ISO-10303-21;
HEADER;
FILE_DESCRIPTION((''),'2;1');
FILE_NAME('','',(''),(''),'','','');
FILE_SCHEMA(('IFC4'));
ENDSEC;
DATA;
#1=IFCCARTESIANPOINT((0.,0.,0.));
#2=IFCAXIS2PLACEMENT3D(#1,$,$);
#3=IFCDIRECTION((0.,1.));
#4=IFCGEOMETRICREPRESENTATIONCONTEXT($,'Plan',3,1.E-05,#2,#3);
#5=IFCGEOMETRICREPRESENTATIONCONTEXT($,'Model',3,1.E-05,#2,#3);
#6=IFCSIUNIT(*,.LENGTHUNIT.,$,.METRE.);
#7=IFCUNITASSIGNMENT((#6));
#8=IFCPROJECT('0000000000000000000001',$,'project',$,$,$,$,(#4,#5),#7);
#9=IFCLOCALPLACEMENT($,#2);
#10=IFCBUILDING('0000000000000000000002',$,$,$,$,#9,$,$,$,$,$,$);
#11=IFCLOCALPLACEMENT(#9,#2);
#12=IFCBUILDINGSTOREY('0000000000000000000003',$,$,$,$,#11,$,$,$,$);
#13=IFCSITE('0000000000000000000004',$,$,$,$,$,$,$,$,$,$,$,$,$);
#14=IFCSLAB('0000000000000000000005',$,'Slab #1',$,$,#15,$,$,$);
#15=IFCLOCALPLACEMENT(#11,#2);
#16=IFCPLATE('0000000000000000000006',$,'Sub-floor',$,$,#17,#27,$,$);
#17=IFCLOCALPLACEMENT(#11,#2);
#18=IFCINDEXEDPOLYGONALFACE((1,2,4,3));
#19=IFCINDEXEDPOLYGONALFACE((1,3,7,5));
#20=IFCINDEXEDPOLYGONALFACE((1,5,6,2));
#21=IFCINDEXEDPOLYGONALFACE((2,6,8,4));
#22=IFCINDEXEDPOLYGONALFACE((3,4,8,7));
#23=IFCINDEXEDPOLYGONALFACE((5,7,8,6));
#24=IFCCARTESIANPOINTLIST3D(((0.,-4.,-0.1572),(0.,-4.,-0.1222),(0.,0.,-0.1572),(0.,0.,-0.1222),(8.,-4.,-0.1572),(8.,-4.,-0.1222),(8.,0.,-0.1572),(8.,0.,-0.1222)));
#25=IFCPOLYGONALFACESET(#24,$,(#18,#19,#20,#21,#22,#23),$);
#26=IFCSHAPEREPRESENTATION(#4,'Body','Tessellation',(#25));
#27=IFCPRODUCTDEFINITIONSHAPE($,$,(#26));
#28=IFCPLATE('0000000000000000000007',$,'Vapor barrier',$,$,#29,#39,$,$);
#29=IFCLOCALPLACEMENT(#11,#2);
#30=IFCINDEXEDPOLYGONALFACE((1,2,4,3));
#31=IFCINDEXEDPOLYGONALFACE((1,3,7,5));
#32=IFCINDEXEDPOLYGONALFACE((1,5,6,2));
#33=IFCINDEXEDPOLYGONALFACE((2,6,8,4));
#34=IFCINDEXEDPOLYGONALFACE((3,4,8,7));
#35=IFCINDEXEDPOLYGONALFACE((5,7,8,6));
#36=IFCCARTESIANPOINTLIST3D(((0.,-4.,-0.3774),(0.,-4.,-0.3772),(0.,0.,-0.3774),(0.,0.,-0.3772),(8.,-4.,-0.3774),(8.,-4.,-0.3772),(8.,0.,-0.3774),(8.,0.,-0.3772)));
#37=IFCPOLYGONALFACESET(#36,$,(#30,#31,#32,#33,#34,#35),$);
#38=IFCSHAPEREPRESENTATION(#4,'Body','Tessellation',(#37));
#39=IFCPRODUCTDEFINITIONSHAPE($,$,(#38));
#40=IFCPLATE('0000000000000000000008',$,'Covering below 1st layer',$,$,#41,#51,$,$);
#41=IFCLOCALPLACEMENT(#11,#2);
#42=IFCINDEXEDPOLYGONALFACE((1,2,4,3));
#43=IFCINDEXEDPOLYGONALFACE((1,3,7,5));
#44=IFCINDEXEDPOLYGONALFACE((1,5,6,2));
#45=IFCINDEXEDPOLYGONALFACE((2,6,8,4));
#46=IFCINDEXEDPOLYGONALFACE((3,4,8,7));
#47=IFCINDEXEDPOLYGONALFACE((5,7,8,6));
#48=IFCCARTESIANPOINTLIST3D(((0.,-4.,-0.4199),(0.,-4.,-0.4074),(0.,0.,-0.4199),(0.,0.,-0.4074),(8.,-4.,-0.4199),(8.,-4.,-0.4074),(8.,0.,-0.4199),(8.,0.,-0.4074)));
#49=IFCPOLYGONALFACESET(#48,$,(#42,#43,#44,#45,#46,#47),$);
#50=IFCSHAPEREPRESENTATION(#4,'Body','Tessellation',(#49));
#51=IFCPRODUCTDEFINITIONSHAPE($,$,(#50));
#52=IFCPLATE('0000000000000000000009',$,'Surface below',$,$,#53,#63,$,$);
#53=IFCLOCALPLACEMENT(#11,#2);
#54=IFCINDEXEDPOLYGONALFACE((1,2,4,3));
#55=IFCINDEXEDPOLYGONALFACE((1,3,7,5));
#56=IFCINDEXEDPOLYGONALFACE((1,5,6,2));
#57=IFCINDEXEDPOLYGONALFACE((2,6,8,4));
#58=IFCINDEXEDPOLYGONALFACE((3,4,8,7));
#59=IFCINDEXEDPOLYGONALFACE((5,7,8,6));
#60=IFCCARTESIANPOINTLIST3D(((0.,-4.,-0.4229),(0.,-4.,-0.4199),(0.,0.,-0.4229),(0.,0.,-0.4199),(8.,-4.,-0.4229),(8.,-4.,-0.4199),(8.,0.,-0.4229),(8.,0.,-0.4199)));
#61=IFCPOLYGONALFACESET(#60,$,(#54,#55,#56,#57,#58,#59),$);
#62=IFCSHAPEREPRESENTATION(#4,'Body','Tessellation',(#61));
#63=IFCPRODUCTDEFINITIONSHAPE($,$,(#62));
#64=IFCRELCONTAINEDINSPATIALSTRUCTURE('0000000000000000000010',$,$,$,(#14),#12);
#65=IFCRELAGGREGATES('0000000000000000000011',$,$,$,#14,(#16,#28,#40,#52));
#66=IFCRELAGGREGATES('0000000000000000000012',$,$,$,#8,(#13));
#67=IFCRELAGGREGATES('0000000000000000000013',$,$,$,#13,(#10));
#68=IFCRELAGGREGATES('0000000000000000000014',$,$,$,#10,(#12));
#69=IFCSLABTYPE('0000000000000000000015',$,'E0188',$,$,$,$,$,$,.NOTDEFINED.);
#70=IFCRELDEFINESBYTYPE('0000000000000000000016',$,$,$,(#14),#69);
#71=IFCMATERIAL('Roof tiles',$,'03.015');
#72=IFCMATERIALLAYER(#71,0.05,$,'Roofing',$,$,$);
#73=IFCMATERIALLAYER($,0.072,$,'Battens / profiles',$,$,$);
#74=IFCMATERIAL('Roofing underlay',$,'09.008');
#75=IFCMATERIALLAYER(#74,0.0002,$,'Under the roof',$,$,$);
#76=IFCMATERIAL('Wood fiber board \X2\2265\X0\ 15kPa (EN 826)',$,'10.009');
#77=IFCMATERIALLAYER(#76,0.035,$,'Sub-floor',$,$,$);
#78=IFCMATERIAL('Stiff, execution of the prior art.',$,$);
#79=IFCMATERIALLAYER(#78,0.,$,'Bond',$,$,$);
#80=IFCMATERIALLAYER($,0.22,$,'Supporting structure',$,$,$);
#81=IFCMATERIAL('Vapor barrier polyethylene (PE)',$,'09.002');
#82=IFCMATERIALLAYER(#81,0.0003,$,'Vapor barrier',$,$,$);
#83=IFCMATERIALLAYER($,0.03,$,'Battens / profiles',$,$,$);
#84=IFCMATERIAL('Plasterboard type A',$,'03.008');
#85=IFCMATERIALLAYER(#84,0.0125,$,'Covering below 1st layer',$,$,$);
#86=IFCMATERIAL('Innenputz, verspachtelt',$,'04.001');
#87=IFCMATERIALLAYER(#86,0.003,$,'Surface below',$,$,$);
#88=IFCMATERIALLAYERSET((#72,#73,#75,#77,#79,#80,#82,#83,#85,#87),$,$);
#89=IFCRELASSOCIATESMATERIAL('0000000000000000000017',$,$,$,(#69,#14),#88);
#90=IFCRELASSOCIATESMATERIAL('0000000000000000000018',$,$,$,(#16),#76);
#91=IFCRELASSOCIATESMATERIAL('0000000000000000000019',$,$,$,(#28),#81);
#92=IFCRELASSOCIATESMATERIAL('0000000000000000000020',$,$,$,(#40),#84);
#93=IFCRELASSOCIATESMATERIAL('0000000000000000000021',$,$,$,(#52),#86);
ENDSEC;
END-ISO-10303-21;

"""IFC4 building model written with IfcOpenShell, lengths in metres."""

from ifc_helpers import new_model, si_unit, direction, frame, frame_2d, origin, place, context, project, spatial, rectangle, extrude, material, layer, layer_set, type_object, element, aggregate, save


model = new_model("IFC4")

# Units and contexts
plan_context = context("Plan", 3, precision=1e-05, world=origin(), true_north=direction((0.0, 1.0)))
model_context = context("Model", 3, precision=1e-05, world=origin(), true_north=direction((0.0, 1.0)))
ifc_project = project(units=[si_unit("LENGTHUNIT", "METRE")], contexts=[plan_context, model_context])

# Site, building, storey
site = spatial("IfcSite", under=ifc_project)
building_placement = place(None, origin())
building = spatial("IfcBuilding", under=site, at=building_placement)
storey_placement = place(building_placement, origin())
storey = spatial("IfcBuildingStorey", under=building, at=storey_placement)

# Slab, plates
ifc_material_1 = material(Name="Roof tiles", Category="03.015")
ifc_layer_1 = layer(ifc_material_1, 0.05, Name="Roofing")
ifc_layer_2 = layer(None, 0.072, Name="Battens / profiles")
ifc_material_2 = material(Name="Roofing underlay", Category="09.008")
ifc_layer_3 = layer(ifc_material_2, 0.0002, Name="Under the roof")
ifc_material_3 = material(Name="Wood fiber board ≥ 15kPa (EN 826)", Category="10.009")
ifc_layer_4 = layer(ifc_material_3, 0.035, Name="Sub-floor")
ifc_material_4 = material(Name="Stiff, execution of the prior art.")
ifc_layer_5 = layer(ifc_material_4, 0.0, Name="Bond")
ifc_layer_6 = layer(None, 0.22, Name="Supporting structure")
ifc_material_5 = material(Name="Vapor barrier polyethylene (PE)", Category="09.002")
ifc_layer_7 = layer(ifc_material_5, 0.0003, Name="Vapor barrier")
ifc_layer_8 = layer(None, 0.03, Name="Battens / profiles")
ifc_material_6 = material(Name="Plasterboard type A", Category="03.008")
ifc_layer_9 = layer(ifc_material_6, 0.0125, Name="Covering below 1st layer")
ifc_material_7 = material(Name="Innenputz, verspachtelt", Category="04.001")
ifc_layer_10 = layer(ifc_material_7, 0.003, Name="Surface below")
ifc_layer_set = layer_set([ifc_layer_1, ifc_layer_2, ifc_layer_3, ifc_layer_4, ifc_layer_5, ifc_layer_6, ifc_layer_7, ifc_layer_8, ifc_layer_9, ifc_layer_10])
slab_type = type_object("IfcSlabType", Name="E0188", PredefinedType="NOTDEFINED", material=ifc_layer_set)
slab_placement = place(None, frame((0.0, 0.0, 0.0), z_axis=(0.0, 0.0, -1.0), x_axis=(1.0, 0.0, 0.0)))
slab = element("IfcSlab", 1, at=slab_placement, inside=storey, type_object=slab_type, material=ifc_layer_set, Name="Slab #1")
plate_1_placement = place(slab_placement, origin())
plate_1 = element("IfcPlate", 2, at=plate_1_placement, material=ifc_material_3, Name="Sub-floor", context=plan_context, shape_type="SweptSolid", body=[
    extrude(rectangle(XDim=8.0, YDim=4.0, at=frame_2d((4.0, 2.0), x_axis=(1.0, 0.0))), frame((0.0, 0.0, 0.1222), z_axis=(0.0, 0.0, 1.0), x_axis=(1.0, 0.0, 0.0)), (0.0, 0.0, 1.0), 0.035),
])
plate_2_placement = place(slab_placement, origin())
plate_2 = element("IfcPlate", 3, at=plate_2_placement, material=ifc_material_5, Name="Vapor barrier", context=plan_context, shape_type="SweptSolid", body=[
    extrude(rectangle(XDim=8.0, YDim=4.0, at=frame_2d((4.0, 2.0), x_axis=(1.0, 0.0))), frame((0.0, 0.0, 0.3772), z_axis=(0.0, 0.0, 1.0), x_axis=(1.0, 0.0, 0.0)), (0.0, 0.0, 1.0), 0.0003),
])
plate_3_placement = place(slab_placement, origin())
plate_3 = element("IfcPlate", 4, at=plate_3_placement, material=ifc_material_6, Name="Covering below 1st layer", context=plan_context, shape_type="SweptSolid", body=[
    extrude(rectangle(XDim=8.0, YDim=4.0, at=frame_2d((4.0, 2.0), x_axis=(1.0, 0.0))), frame((0.0, 0.0, 0.4074), z_axis=(0.0, 0.0, 1.0), x_axis=(1.0, 0.0, 0.0)), (0.0, 0.0, 1.0), 0.0125),
])
plate_4_placement = place(slab_placement, origin())
plate_4 = element("IfcPlate", 5, at=plate_4_placement, material=ifc_material_7, Name="Surface below", context=plan_context, shape_type="SweptSolid", body=[
    extrude(rectangle(XDim=8.0, YDim=4.0, at=frame_2d((4.0, 2.0), x_axis=(1.0, 0.0))), frame((0.0, 0.0, 0.4199), z_axis=(0.0, 0.0, 1.0), x_axis=(1.0, 0.0, 0.0)), (0.0, 0.0, 1.0), 0.003),
])
aggregate(slab, [plate_1, plate_2, plate_3, plate_4])

save(model, "model.ifc")
